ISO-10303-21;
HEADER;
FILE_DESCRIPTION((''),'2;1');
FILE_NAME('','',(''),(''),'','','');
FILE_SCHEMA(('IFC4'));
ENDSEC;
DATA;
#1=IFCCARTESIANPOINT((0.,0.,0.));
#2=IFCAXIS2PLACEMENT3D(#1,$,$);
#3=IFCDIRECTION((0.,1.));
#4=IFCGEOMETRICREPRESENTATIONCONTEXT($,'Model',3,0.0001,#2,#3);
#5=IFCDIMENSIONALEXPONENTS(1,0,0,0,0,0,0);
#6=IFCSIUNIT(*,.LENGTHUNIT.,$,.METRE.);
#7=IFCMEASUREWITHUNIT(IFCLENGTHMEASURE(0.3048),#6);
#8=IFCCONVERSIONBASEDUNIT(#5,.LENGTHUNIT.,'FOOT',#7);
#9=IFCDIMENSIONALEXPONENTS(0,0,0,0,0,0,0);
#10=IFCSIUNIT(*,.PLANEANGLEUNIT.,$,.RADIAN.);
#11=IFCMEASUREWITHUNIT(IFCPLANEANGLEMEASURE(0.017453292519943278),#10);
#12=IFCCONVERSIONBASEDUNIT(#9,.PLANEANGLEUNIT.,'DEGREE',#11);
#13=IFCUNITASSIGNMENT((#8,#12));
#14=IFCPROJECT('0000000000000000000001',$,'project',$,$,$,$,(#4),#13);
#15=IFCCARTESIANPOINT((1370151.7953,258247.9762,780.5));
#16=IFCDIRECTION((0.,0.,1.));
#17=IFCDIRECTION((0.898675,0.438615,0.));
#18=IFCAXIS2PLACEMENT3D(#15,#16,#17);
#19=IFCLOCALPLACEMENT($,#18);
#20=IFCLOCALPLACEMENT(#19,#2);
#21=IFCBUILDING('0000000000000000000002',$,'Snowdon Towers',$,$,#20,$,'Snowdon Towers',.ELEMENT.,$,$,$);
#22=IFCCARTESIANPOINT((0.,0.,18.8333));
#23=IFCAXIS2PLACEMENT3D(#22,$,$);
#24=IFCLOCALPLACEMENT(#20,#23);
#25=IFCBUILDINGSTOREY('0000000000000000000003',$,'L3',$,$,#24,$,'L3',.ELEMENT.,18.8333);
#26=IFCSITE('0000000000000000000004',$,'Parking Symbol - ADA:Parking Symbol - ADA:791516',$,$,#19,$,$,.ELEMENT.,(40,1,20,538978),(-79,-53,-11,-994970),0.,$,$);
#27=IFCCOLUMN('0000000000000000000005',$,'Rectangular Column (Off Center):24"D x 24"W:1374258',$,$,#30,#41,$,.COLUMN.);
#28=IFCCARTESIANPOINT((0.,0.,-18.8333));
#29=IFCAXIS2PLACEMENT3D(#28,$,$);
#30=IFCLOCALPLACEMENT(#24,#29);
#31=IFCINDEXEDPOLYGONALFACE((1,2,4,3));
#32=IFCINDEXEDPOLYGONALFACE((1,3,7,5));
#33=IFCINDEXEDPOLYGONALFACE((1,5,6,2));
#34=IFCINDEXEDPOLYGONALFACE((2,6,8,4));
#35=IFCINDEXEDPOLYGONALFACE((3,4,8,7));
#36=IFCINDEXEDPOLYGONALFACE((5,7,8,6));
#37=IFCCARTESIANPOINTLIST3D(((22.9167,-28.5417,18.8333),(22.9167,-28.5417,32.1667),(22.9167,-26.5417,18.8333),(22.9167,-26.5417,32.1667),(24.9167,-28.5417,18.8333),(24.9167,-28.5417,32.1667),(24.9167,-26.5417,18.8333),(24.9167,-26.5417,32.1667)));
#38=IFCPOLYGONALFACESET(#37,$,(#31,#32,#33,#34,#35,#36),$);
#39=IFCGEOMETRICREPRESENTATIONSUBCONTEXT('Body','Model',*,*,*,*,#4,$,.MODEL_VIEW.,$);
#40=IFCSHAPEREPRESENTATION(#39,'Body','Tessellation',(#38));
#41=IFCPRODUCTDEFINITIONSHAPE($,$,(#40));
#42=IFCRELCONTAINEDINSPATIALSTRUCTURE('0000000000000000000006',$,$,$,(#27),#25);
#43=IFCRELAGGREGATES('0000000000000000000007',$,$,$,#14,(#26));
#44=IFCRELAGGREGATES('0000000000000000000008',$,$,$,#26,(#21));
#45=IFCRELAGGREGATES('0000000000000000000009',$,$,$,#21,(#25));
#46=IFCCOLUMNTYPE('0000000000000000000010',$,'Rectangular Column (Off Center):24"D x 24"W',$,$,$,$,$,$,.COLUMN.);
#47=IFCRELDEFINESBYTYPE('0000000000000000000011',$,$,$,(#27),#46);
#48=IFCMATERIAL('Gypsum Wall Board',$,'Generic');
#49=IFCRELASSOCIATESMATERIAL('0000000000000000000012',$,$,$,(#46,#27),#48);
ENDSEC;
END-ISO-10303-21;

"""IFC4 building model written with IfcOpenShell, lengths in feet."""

from ifc_helpers import new_model, entity, si_unit, converted_unit, direction, frame, origin, place, context, subcontext, project, spatial, indexed_curve, outline, extrude, source, transform, mapped, material, type_object, type_shapes, element, save


model = new_model("IFC4")

# Units and contexts
model_context = context("Model", 3, precision=0.0001, world=origin(), true_north=direction((0.0, 1.0)))
body_context = subcontext(model_context, "Body", "Model", "MODEL_VIEW")
ifc_project = project(units=[converted_unit("LENGTHUNIT", "FOOT", entity("IfcLengthMeasure", 0.3048), si_unit("LENGTHUNIT", "METRE"), dimensions=[1, 0, 0, 0, 0, 0, 0]), converted_unit("PLANEANGLEUNIT", "DEGREE", entity("IfcPlaneAngleMeasure", 0.017453292519943278), si_unit("PLANEANGLEUNIT", "RADIAN"), dimensions=[0, 0, 0, 0, 0, 0, 0])], contexts=[model_context])

# Site, building, storey
site_placement = place(None, frame((1370151.7953, 258247.9762, 780.5), z_axis=(0.0, 0.0, 1.0), x_axis=(0.898675, 0.438615, 0.0)))
site = spatial("IfcSite", under=ifc_project, at=site_placement, Name="Parking Symbol - ADA:Parking Symbol - ADA:791516", CompositionType="ELEMENT", RefLatitude=(40, 1, 20, 538978), RefLongitude=(-79, -53, -11, -994970), RefElevation=0.0)
building_placement = place(site_placement, origin())
building = spatial("IfcBuilding", under=site, at=building_placement, Name="Snowdon Towers", LongName="Snowdon Towers", CompositionType="ELEMENT")
storey_placement = place(building_placement, frame((0.0, 0.0, 18.8333)))
storey = spatial("IfcBuildingStorey", under=building, at=storey_placement, Name="L3", LongName="L3", CompositionType="ELEMENT", Elevation=18.8333)

# Column
ifc_material_1 = material(Name="Gypsum Wall Board", Category="Generic")
column_type_1 = type_object("IfcColumnType", Name="Rectangular Column (Off Center):24\"D x 24\"W", PredefinedType="COLUMN", material=ifc_material_1)
shared_shape_1 = source(origin(), body_context, "Body", "SweptSolid", [
    extrude(outline(indexed_curve([(-1.0, -1.0), (1.0, -1.0), (1.0, 1.0), (-1.0, 1.0), (-1.0, -1.0)], self_intersect=False)), frame((23.9167, -27.5417, 18.8333), z_axis=(0.0, 0.0, 1.0), x_axis=(-1.0, 0.0, 0.0)), (0.0, 0.0, 1.0), 13.3333),
])
type_shapes(column_type_1, [shared_shape_1])
column_1_placement = place(storey_placement, frame((0.0, 0.0, -18.8333)))
element("IfcColumn", 1, at=column_1_placement, inside=storey, type_object=column_type_1, material=ifc_material_1, Name="Rectangular Column (Off Center):24\"D x 24\"W:1374258", PredefinedType="COLUMN", context=body_context, shape_type="MappedRepresentation", body=[
    mapped(shared_shape_1, transform((0.0, 0.0, 0.0), scale=1.0)),
])

save(model, "model.ifc")
